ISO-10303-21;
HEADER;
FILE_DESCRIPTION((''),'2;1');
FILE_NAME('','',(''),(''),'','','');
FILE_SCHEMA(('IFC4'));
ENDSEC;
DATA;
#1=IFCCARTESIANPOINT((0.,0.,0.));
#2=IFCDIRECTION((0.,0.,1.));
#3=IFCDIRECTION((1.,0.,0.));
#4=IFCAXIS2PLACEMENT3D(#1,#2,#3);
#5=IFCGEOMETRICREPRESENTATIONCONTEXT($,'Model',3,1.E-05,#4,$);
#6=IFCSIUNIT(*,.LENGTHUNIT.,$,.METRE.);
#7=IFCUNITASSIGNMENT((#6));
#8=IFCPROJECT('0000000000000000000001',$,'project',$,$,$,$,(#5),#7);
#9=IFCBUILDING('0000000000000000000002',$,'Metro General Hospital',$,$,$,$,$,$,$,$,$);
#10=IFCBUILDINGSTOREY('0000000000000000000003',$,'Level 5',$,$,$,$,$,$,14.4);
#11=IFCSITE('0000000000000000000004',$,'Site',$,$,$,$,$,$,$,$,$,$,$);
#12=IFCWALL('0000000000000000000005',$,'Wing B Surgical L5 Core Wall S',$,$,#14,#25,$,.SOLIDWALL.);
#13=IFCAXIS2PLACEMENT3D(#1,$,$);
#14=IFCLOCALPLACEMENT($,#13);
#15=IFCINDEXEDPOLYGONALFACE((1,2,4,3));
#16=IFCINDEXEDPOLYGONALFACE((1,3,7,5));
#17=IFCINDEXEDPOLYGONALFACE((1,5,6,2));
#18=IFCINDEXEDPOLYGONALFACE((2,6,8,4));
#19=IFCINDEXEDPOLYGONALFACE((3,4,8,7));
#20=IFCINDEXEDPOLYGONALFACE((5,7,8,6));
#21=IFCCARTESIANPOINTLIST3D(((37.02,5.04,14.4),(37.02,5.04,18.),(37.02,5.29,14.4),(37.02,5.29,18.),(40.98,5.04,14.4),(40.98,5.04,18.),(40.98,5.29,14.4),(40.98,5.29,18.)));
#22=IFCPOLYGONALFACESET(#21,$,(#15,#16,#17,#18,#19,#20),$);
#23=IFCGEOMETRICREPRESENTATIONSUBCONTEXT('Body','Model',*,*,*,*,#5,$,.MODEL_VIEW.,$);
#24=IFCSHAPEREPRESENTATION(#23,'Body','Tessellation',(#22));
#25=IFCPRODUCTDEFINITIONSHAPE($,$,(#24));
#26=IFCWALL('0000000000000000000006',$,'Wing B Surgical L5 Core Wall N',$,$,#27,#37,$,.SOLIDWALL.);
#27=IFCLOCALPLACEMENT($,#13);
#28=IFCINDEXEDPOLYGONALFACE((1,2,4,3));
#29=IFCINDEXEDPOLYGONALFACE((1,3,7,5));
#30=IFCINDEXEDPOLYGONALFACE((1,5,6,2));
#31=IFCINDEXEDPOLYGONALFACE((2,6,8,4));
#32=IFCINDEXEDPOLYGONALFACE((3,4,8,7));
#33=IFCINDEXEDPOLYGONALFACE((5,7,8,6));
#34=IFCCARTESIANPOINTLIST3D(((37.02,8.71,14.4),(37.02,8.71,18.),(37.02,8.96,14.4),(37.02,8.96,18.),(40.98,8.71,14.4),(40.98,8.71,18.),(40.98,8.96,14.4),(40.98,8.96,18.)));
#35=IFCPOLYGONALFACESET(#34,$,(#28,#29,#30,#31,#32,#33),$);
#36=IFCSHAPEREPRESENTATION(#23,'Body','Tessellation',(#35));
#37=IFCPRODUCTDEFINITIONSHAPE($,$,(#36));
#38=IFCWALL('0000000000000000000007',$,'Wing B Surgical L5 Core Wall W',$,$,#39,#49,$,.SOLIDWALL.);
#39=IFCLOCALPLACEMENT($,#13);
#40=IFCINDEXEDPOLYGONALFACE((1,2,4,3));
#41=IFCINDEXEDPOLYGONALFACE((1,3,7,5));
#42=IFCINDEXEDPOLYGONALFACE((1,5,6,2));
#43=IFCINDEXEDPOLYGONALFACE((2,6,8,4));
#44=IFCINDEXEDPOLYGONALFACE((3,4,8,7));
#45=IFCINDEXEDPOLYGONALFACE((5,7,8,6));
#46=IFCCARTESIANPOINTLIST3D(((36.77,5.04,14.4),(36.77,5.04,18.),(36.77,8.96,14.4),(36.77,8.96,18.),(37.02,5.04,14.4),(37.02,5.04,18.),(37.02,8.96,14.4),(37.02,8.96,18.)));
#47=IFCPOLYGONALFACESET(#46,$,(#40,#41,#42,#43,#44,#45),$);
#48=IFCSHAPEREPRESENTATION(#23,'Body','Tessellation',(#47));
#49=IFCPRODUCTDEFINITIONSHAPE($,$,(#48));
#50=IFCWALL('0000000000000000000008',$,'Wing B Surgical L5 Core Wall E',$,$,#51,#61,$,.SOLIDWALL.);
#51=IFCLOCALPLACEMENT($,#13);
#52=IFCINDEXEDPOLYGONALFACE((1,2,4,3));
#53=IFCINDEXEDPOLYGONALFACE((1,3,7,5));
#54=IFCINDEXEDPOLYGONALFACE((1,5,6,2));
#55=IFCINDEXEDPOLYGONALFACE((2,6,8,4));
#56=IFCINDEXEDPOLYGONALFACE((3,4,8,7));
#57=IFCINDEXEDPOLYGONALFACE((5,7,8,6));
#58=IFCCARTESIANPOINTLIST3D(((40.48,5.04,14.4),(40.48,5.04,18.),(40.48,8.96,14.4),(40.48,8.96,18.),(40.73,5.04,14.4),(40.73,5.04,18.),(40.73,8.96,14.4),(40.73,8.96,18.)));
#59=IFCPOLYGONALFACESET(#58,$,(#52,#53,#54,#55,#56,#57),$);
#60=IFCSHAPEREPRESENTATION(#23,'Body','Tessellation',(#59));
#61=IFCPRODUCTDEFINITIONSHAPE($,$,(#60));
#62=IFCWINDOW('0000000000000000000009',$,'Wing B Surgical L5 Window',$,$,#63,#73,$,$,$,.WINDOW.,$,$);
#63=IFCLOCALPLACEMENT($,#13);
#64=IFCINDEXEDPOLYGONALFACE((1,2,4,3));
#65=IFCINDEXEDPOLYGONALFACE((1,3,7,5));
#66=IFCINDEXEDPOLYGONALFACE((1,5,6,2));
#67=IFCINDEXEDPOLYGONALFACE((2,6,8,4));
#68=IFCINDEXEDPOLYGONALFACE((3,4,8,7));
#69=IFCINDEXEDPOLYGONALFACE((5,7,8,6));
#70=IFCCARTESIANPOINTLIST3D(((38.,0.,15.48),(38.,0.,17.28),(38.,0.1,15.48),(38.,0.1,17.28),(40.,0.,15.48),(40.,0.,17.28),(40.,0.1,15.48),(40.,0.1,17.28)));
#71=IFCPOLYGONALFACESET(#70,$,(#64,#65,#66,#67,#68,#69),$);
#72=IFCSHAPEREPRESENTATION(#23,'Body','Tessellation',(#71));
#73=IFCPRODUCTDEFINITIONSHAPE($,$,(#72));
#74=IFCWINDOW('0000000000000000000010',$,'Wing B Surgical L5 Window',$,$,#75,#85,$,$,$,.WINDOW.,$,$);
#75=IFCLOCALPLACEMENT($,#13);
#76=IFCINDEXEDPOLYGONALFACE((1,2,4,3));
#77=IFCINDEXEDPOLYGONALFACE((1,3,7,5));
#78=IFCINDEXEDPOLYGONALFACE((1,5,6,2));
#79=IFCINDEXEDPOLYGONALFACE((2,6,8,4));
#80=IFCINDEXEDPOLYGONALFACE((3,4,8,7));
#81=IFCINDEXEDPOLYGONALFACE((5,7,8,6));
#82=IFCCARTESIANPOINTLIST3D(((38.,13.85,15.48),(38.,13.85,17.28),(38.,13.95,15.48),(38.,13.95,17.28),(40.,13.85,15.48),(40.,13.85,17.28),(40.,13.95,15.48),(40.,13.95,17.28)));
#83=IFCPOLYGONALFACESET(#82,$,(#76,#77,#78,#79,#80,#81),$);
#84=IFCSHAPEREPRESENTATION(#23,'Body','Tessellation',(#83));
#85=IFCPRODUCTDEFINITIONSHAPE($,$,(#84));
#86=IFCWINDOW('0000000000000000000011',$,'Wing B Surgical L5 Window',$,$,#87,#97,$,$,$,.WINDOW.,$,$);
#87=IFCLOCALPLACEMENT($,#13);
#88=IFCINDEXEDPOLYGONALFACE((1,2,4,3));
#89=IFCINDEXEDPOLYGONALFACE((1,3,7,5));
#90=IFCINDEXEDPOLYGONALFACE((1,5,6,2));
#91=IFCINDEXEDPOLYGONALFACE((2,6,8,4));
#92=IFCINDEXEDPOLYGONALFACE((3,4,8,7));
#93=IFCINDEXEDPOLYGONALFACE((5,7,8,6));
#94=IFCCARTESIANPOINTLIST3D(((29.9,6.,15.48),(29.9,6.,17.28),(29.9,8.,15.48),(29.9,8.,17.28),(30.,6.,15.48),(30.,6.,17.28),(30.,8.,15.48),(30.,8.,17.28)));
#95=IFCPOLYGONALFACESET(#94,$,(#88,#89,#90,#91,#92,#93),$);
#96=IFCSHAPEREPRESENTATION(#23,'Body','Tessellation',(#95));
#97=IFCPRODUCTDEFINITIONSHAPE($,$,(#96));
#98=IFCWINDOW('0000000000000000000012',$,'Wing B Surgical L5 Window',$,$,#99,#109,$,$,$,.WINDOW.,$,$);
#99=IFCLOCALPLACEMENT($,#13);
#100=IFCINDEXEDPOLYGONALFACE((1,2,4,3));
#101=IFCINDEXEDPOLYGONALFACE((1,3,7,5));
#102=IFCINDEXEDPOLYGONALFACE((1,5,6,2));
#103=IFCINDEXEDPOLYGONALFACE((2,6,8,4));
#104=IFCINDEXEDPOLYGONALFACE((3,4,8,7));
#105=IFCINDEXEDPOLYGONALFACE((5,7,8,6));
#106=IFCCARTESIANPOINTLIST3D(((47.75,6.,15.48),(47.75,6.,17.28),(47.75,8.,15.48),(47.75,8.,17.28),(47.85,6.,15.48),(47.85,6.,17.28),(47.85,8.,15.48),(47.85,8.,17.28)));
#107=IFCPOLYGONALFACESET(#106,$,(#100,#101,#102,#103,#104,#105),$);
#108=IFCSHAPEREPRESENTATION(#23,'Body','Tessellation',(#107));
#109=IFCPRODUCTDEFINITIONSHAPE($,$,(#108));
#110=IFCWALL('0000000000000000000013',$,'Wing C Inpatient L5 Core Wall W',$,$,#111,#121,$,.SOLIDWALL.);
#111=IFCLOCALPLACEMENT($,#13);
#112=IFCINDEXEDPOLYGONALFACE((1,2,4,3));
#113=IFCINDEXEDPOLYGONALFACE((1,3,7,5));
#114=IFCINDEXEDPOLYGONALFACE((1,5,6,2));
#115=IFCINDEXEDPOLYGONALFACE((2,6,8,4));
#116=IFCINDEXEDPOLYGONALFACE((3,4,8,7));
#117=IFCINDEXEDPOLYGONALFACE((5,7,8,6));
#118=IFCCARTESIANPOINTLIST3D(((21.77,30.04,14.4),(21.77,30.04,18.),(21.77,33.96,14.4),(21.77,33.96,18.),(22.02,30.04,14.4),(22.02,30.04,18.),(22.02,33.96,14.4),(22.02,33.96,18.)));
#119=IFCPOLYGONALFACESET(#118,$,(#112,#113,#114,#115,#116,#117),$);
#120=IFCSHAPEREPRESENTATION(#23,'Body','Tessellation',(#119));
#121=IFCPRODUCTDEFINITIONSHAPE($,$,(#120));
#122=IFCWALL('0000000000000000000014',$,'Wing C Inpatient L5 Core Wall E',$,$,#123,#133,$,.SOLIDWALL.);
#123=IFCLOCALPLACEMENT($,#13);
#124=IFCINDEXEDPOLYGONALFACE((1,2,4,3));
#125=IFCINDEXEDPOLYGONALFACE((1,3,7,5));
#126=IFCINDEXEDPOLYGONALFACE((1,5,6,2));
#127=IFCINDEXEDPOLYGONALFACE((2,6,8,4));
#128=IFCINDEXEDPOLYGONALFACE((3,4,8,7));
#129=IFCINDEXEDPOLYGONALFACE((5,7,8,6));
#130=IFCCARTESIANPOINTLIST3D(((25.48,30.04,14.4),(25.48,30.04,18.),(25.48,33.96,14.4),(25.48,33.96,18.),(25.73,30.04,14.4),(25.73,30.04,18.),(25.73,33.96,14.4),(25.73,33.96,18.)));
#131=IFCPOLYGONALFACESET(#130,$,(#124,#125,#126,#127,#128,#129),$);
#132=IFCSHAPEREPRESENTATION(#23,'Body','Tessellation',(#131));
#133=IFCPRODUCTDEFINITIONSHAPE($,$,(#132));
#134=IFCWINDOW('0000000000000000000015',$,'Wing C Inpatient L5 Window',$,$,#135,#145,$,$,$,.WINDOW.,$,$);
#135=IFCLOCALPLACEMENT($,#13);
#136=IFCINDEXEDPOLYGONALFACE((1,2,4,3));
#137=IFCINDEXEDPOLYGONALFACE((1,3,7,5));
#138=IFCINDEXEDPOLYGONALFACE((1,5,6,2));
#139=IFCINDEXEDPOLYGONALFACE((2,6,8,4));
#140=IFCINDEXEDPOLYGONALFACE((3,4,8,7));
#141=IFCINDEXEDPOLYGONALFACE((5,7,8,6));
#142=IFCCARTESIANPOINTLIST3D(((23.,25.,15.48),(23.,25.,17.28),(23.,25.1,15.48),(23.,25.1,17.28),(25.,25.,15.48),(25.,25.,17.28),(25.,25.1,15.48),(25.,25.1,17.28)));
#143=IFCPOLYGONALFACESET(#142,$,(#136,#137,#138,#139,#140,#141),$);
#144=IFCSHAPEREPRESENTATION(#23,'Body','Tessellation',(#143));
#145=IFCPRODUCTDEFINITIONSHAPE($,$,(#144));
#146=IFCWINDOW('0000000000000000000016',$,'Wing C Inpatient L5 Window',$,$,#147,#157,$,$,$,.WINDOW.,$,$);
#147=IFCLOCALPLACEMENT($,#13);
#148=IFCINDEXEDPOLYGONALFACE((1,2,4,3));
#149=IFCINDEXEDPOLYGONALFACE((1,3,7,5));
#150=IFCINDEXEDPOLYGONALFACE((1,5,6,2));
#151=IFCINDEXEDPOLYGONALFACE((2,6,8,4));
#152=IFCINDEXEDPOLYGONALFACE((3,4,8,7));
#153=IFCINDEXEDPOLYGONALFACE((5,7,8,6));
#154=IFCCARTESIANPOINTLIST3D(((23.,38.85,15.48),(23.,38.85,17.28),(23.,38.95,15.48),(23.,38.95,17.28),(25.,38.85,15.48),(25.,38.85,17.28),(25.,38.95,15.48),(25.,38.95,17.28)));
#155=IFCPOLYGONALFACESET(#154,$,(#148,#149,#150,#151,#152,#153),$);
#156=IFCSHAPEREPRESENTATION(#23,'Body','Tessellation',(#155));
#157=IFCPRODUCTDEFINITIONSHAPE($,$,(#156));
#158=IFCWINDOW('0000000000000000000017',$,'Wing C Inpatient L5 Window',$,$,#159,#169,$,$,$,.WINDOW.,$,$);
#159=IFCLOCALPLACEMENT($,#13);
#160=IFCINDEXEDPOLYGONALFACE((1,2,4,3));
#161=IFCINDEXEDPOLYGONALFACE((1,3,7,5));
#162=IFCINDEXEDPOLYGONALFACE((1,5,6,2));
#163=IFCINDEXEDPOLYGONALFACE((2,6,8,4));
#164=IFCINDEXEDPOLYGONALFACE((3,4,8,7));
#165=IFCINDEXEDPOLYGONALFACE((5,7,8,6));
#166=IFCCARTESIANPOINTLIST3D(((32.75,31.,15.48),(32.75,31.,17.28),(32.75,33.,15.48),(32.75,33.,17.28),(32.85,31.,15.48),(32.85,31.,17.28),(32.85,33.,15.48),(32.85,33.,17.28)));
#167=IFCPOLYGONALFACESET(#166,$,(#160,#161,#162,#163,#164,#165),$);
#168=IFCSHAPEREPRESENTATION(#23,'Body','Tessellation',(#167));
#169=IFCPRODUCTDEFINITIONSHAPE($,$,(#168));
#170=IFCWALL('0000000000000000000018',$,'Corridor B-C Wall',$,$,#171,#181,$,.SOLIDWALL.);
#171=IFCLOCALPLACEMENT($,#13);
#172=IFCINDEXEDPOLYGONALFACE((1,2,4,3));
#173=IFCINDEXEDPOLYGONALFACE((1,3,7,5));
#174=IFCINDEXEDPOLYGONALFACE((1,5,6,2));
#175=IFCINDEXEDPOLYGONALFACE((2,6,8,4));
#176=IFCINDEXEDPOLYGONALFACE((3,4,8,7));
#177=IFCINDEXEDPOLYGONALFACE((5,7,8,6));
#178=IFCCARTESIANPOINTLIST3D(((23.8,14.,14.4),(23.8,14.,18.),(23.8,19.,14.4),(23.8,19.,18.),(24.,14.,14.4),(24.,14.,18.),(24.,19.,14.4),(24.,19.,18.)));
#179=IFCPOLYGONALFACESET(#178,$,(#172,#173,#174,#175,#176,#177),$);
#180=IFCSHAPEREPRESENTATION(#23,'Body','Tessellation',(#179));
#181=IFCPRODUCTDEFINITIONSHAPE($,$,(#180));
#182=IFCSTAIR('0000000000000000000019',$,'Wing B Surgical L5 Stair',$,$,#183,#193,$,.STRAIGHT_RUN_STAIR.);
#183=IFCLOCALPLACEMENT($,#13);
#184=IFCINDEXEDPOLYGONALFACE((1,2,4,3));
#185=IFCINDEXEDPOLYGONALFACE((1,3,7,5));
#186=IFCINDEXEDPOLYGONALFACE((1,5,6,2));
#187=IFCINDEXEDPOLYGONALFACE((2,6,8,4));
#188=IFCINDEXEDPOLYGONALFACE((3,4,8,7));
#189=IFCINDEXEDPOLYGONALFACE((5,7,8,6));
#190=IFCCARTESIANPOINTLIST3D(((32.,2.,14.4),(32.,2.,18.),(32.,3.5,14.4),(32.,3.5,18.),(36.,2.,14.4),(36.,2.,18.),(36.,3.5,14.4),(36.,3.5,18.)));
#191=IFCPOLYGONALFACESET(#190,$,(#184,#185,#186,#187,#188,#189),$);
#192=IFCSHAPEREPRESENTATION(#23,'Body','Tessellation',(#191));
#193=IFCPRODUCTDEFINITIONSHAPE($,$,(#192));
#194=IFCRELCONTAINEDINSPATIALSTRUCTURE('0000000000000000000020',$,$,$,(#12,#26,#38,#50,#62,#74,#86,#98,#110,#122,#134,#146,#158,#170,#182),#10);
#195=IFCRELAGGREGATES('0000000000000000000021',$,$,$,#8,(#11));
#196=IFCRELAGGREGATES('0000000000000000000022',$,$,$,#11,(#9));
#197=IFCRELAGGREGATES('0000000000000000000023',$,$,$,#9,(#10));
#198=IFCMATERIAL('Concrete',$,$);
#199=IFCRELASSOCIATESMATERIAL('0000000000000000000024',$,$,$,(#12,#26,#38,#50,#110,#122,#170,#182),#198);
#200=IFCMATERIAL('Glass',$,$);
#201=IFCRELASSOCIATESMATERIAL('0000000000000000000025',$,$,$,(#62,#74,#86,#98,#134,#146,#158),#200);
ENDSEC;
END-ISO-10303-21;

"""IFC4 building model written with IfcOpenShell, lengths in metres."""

from ifc_helpers import new_model, si_unit, frame, origin_with_axes, place, context, subcontext, project, spatial, line, indexed_curve, outline, extrude, material, element, save


model = new_model("IFC4")

# Units and contexts
model_context = context("Model", 3, precision=1e-05, world=origin_with_axes())
body_context = subcontext(model_context, "Body", "Model", "MODEL_VIEW")
ifc_project = project(units=[si_unit("LENGTHUNIT", "METRE")], contexts=[model_context])

# Site, building, storey
site = spatial("IfcSite", under=ifc_project, Name="Site")
building = spatial("IfcBuilding", under=site, Name="Metro General Hospital")
storey = spatial("IfcBuildingStorey", under=building, Name="Level 5", Elevation=14.4)

# Shared definitions
ifc_material_1 = material(Name="Concrete")

# Walls
for number, where, z_axis, x_axis, name in (
    (1, (37.02, 5.04, 14.4), (0.0, 0.0, 1.0), (1.0, 0.0, 0.0), "Wing B Surgical L5 Core Wall S"),
    (2, (37.02, 8.71, 14.4), (0.0, 0.0, 1.0), (1.0, 0.0, 0.0), "Wing B Surgical L5 Core Wall N"),
):
    element("IfcWall", number, at=place(None, frame(where, z_axis=z_axis, x_axis=x_axis)), inside=storey, material=ifc_material_1, Name=name, PredefinedType="SOLIDWALL", context=body_context, shape_type="SweptSolid", body=[
        extrude(outline(indexed_curve([(0.0, 0.0), (3.96, 0.0), (3.96, 0.25), (0.0, 0.25)], segments=[line(1, 2, 3, 4, 1)])), origin_with_axes(), (0.0, 0.0, 1.0), 3.6),
    ])
for number, where, z_axis, x_axis, name in (
    (3, (37.02, 5.04, 14.4), (0.0, 0.0, 1.0), (0.0, 1.0, 0.0), "Wing B Surgical L5 Core Wall W"),
    (4, (40.73, 5.04, 14.4), (0.0, 0.0, 1.0), (0.0, 1.0, 0.0), "Wing B Surgical L5 Core Wall E"),
):
    element("IfcWall", number, at=place(None, frame(where, z_axis=z_axis, x_axis=x_axis)), inside=storey, material=ifc_material_1, Name=name, PredefinedType="SOLIDWALL", context=body_context, shape_type="SweptSolid", body=[
        extrude(outline(indexed_curve([(0.0, 0.0), (3.92, 0.0), (3.92, 0.25), (0.0, 0.25)], segments=[line(1, 2, 3, 4, 1)])), origin_with_axes(), (0.0, 0.0, 1.0), 3.6),
    ])

# Windows
ifc_material_2 = material(Name="Glass")
for number, where, z_axis, x_axis, name in (
    (5, (38.0, 0.0, 15.48), (0.0, 0.0, 1.0), (1.0, 0.0, 0.0), "Wing B Surgical L5 Window"),
    (6, (38.0, 13.85, 15.48), (0.0, 0.0, 1.0), (1.0, 0.0, 0.0), "Wing B Surgical L5 Window"),
    (7, (30.0, 6.0, 15.48), (0.0, 0.0, 1.0), (0.0, 1.0, 0.0), "Wing B Surgical L5 Window"),
    (8, (47.85, 6.0, 15.48), (0.0, 0.0, 1.0), (0.0, 1.0, 0.0), "Wing B Surgical L5 Window"),
):
    element("IfcWindow", number, at=place(None, frame(where, z_axis=z_axis, x_axis=x_axis)), inside=storey, material=ifc_material_2, Name=name, PredefinedType="WINDOW", context=body_context, shape_type="SweptSolid", body=[
        extrude(outline(indexed_curve([(0.0, 0.0), (2.0, 0.0), (2.0, 0.1), (0.0, 0.1)], segments=[line(1, 2, 3, 4, 1)])), origin_with_axes(), (0.0, 0.0, 1.0), 1.8),
    ])

# Walls
for number, where, z_axis, x_axis, name in (
    (9, (22.02, 30.04, 14.4), (0.0, 0.0, 1.0), (0.0, 1.0, 0.0), "Wing C Inpatient L5 Core Wall W"),
    (10, (25.73, 30.04, 14.4), (0.0, 0.0, 1.0), (0.0, 1.0, 0.0), "Wing C Inpatient L5 Core Wall E"),
):
    element("IfcWall", number, at=place(None, frame(where, z_axis=z_axis, x_axis=x_axis)), inside=storey, material=ifc_material_1, Name=name, PredefinedType="SOLIDWALL", context=body_context, shape_type="SweptSolid", body=[
        extrude(outline(indexed_curve([(0.0, 0.0), (3.92, 0.0), (3.92, 0.25), (0.0, 0.25)], segments=[line(1, 2, 3, 4, 1)])), origin_with_axes(), (0.0, 0.0, 1.0), 3.6),
    ])

# Windows
for number, where, z_axis, x_axis, name in (
    (11, (23.0, 25.0, 15.48), (0.0, 0.0, 1.0), (1.0, 0.0, 0.0), "Wing C Inpatient L5 Window"),
    (12, (23.0, 38.85, 15.48), (0.0, 0.0, 1.0), (1.0, 0.0, 0.0), "Wing C Inpatient L5 Window"),
    (13, (32.85, 31.0, 15.48), (0.0, 0.0, 1.0), (0.0, 1.0, 0.0), "Wing C Inpatient L5 Window"),
):
    element("IfcWindow", number, at=place(None, frame(where, z_axis=z_axis, x_axis=x_axis)), inside=storey, material=ifc_material_2, Name=name, PredefinedType="WINDOW", context=body_context, shape_type="SweptSolid", body=[
        extrude(outline(indexed_curve([(0.0, 0.0), (2.0, 0.0), (2.0, 0.1), (0.0, 0.1)], segments=[line(1, 2, 3, 4, 1)])), origin_with_axes(), (0.0, 0.0, 1.0), 1.8),
    ])

# Wall
wall_placement = place(None, frame((24.0, 14.0, 14.4), z_axis=(0.0, 0.0, 1.0), x_axis=(0.0, 1.0, 0.0)))
element("IfcWall", 14, at=wall_placement, inside=storey, material=ifc_material_1, Name="Corridor B-C Wall", PredefinedType="SOLIDWALL", context=body_context, shape_type="SweptSolid", body=[
    extrude(outline(indexed_curve([(0.0, 0.0), (5.0, 0.0), (5.0, 0.2), (0.0, 0.2)], segments=[line(1, 2, 3, 4, 1)])), origin_with_axes(), (0.0, 0.0, 1.0), 3.6),
])

# Stair
stair_placement = place(None, frame((32.0, 2.0, 14.4), z_axis=(0.0, 0.0, 1.0), x_axis=(1.0, 0.0, 0.0)))
element("IfcStair", 15, at=stair_placement, inside=storey, material=ifc_material_1, Name="Wing B Surgical L5 Stair", PredefinedType="STRAIGHT_RUN_STAIR", context=body_context, shape_type="SweptSolid", body=[
    extrude(outline(indexed_curve([(0.0, 0.0), (4.0, 0.0), (4.0, 1.5), (0.0, 1.5)], segments=[line(1, 2, 3, 4, 1)])), origin_with_axes(), (0.0, 0.0, 1.0), 3.6),
])

save(model, "model.ifc")
